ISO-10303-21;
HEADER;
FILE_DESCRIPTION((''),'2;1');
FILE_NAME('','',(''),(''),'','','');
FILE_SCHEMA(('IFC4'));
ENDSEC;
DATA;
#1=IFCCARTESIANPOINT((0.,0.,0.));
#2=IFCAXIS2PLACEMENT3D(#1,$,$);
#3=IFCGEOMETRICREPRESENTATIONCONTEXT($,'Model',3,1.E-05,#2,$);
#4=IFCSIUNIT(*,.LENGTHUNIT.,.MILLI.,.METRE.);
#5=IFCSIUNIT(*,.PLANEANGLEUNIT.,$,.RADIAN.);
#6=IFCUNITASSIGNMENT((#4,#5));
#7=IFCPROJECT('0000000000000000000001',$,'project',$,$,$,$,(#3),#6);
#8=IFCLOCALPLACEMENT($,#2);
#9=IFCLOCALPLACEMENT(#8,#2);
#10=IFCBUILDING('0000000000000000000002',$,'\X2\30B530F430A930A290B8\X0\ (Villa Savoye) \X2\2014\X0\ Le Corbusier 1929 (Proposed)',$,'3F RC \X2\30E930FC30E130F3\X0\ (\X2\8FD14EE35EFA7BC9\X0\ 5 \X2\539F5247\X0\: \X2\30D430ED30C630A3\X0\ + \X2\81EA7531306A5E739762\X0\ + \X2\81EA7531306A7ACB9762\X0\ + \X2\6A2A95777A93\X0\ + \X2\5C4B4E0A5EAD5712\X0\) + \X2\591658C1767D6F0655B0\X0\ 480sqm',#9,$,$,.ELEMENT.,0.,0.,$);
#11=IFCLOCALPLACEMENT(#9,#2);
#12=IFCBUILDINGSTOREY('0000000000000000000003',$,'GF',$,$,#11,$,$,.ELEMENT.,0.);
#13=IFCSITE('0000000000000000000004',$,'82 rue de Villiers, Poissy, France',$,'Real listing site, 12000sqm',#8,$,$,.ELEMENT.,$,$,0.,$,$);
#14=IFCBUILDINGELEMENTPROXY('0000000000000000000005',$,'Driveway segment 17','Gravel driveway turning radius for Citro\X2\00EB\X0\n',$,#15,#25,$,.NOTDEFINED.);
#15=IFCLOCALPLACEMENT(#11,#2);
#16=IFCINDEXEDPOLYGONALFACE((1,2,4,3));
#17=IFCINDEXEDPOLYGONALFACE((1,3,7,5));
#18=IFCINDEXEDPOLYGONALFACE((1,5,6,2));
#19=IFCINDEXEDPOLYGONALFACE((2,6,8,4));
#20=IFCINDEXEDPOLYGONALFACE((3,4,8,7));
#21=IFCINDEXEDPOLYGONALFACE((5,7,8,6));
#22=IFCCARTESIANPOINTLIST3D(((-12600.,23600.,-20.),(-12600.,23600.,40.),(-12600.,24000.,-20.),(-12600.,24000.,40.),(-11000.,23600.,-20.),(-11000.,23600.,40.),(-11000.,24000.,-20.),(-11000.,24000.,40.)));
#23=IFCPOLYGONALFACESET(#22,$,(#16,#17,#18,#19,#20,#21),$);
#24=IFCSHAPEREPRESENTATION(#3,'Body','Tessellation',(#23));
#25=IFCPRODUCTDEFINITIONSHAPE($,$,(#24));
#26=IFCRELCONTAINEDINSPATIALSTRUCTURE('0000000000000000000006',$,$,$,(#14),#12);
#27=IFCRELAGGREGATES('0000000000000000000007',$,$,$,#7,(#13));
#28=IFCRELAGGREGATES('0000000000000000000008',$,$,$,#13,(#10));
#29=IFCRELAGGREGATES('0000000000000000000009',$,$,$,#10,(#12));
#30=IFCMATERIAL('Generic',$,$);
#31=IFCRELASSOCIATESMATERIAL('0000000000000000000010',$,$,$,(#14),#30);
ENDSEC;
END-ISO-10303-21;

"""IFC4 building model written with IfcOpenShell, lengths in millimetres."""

from ifc_helpers import new_model, si_unit, frame, frame_2d, origin, place, context, project, spatial, rectangle, extrude, material, element, save


model = new_model("IFC4")

# Units and contexts
model_context = context("Model", 3, precision=1e-05, world=origin())
ifc_project = project(units=[si_unit("LENGTHUNIT", "METRE", prefix="MILLI"), si_unit("PLANEANGLEUNIT", "RADIAN")], contexts=[model_context])

# Site, building, storey
site_placement = place(None, origin())
site = spatial("IfcSite", under=ifc_project, at=site_placement, Name="82 rue de Villiers, Poissy, France", ObjectType="Real listing site, 12000sqm", CompositionType="ELEMENT", RefElevation=0.0)
building_placement = place(site_placement, origin())
building = spatial("IfcBuilding", under=site, at=building_placement, Name="サヴォア邸 (Villa Savoye) — Le Corbusier 1929 (Proposed)", ObjectType="3F RC ラーメン (近代建築 5 原則: ピロティ + 自由な平面 + 自由な立面 + 横長窓 + 屋上庭園) + 外壁白漆喰 480sqm", CompositionType="ELEMENT", ElevationOfRefHeight=0.0, ElevationOfTerrain=0.0)
storey_placement = place(building_placement, origin())
storey = spatial("IfcBuildingStorey", under=building, at=storey_placement, Name="GF", CompositionType="ELEMENT", Elevation=0.0)

# Shared definitions
ifc_material_1 = material(Name="Generic")

# Building element proxy
proxy_1_placement = place(storey_placement, frame((-6300.0, 11800.0, -10.0)))
element("IfcBuildingElementProxy", 1, at=proxy_1_placement, inside=storey, material=ifc_material_1, Name="Driveway segment 17", Description="Gravel driveway turning radius for Citroën", PredefinedType="NOTDEFINED", context=model_context, shape_type="SweptSolid", body=[
    extrude(rectangle(XDim=1600.0, YDim=400.0, at=frame_2d((800.0, 200.0))), frame((-6300.0, 11800.0, -10.0)), (0.0, 0.0, 1.0), 60.0),
])

save(model, "model.ifc")
